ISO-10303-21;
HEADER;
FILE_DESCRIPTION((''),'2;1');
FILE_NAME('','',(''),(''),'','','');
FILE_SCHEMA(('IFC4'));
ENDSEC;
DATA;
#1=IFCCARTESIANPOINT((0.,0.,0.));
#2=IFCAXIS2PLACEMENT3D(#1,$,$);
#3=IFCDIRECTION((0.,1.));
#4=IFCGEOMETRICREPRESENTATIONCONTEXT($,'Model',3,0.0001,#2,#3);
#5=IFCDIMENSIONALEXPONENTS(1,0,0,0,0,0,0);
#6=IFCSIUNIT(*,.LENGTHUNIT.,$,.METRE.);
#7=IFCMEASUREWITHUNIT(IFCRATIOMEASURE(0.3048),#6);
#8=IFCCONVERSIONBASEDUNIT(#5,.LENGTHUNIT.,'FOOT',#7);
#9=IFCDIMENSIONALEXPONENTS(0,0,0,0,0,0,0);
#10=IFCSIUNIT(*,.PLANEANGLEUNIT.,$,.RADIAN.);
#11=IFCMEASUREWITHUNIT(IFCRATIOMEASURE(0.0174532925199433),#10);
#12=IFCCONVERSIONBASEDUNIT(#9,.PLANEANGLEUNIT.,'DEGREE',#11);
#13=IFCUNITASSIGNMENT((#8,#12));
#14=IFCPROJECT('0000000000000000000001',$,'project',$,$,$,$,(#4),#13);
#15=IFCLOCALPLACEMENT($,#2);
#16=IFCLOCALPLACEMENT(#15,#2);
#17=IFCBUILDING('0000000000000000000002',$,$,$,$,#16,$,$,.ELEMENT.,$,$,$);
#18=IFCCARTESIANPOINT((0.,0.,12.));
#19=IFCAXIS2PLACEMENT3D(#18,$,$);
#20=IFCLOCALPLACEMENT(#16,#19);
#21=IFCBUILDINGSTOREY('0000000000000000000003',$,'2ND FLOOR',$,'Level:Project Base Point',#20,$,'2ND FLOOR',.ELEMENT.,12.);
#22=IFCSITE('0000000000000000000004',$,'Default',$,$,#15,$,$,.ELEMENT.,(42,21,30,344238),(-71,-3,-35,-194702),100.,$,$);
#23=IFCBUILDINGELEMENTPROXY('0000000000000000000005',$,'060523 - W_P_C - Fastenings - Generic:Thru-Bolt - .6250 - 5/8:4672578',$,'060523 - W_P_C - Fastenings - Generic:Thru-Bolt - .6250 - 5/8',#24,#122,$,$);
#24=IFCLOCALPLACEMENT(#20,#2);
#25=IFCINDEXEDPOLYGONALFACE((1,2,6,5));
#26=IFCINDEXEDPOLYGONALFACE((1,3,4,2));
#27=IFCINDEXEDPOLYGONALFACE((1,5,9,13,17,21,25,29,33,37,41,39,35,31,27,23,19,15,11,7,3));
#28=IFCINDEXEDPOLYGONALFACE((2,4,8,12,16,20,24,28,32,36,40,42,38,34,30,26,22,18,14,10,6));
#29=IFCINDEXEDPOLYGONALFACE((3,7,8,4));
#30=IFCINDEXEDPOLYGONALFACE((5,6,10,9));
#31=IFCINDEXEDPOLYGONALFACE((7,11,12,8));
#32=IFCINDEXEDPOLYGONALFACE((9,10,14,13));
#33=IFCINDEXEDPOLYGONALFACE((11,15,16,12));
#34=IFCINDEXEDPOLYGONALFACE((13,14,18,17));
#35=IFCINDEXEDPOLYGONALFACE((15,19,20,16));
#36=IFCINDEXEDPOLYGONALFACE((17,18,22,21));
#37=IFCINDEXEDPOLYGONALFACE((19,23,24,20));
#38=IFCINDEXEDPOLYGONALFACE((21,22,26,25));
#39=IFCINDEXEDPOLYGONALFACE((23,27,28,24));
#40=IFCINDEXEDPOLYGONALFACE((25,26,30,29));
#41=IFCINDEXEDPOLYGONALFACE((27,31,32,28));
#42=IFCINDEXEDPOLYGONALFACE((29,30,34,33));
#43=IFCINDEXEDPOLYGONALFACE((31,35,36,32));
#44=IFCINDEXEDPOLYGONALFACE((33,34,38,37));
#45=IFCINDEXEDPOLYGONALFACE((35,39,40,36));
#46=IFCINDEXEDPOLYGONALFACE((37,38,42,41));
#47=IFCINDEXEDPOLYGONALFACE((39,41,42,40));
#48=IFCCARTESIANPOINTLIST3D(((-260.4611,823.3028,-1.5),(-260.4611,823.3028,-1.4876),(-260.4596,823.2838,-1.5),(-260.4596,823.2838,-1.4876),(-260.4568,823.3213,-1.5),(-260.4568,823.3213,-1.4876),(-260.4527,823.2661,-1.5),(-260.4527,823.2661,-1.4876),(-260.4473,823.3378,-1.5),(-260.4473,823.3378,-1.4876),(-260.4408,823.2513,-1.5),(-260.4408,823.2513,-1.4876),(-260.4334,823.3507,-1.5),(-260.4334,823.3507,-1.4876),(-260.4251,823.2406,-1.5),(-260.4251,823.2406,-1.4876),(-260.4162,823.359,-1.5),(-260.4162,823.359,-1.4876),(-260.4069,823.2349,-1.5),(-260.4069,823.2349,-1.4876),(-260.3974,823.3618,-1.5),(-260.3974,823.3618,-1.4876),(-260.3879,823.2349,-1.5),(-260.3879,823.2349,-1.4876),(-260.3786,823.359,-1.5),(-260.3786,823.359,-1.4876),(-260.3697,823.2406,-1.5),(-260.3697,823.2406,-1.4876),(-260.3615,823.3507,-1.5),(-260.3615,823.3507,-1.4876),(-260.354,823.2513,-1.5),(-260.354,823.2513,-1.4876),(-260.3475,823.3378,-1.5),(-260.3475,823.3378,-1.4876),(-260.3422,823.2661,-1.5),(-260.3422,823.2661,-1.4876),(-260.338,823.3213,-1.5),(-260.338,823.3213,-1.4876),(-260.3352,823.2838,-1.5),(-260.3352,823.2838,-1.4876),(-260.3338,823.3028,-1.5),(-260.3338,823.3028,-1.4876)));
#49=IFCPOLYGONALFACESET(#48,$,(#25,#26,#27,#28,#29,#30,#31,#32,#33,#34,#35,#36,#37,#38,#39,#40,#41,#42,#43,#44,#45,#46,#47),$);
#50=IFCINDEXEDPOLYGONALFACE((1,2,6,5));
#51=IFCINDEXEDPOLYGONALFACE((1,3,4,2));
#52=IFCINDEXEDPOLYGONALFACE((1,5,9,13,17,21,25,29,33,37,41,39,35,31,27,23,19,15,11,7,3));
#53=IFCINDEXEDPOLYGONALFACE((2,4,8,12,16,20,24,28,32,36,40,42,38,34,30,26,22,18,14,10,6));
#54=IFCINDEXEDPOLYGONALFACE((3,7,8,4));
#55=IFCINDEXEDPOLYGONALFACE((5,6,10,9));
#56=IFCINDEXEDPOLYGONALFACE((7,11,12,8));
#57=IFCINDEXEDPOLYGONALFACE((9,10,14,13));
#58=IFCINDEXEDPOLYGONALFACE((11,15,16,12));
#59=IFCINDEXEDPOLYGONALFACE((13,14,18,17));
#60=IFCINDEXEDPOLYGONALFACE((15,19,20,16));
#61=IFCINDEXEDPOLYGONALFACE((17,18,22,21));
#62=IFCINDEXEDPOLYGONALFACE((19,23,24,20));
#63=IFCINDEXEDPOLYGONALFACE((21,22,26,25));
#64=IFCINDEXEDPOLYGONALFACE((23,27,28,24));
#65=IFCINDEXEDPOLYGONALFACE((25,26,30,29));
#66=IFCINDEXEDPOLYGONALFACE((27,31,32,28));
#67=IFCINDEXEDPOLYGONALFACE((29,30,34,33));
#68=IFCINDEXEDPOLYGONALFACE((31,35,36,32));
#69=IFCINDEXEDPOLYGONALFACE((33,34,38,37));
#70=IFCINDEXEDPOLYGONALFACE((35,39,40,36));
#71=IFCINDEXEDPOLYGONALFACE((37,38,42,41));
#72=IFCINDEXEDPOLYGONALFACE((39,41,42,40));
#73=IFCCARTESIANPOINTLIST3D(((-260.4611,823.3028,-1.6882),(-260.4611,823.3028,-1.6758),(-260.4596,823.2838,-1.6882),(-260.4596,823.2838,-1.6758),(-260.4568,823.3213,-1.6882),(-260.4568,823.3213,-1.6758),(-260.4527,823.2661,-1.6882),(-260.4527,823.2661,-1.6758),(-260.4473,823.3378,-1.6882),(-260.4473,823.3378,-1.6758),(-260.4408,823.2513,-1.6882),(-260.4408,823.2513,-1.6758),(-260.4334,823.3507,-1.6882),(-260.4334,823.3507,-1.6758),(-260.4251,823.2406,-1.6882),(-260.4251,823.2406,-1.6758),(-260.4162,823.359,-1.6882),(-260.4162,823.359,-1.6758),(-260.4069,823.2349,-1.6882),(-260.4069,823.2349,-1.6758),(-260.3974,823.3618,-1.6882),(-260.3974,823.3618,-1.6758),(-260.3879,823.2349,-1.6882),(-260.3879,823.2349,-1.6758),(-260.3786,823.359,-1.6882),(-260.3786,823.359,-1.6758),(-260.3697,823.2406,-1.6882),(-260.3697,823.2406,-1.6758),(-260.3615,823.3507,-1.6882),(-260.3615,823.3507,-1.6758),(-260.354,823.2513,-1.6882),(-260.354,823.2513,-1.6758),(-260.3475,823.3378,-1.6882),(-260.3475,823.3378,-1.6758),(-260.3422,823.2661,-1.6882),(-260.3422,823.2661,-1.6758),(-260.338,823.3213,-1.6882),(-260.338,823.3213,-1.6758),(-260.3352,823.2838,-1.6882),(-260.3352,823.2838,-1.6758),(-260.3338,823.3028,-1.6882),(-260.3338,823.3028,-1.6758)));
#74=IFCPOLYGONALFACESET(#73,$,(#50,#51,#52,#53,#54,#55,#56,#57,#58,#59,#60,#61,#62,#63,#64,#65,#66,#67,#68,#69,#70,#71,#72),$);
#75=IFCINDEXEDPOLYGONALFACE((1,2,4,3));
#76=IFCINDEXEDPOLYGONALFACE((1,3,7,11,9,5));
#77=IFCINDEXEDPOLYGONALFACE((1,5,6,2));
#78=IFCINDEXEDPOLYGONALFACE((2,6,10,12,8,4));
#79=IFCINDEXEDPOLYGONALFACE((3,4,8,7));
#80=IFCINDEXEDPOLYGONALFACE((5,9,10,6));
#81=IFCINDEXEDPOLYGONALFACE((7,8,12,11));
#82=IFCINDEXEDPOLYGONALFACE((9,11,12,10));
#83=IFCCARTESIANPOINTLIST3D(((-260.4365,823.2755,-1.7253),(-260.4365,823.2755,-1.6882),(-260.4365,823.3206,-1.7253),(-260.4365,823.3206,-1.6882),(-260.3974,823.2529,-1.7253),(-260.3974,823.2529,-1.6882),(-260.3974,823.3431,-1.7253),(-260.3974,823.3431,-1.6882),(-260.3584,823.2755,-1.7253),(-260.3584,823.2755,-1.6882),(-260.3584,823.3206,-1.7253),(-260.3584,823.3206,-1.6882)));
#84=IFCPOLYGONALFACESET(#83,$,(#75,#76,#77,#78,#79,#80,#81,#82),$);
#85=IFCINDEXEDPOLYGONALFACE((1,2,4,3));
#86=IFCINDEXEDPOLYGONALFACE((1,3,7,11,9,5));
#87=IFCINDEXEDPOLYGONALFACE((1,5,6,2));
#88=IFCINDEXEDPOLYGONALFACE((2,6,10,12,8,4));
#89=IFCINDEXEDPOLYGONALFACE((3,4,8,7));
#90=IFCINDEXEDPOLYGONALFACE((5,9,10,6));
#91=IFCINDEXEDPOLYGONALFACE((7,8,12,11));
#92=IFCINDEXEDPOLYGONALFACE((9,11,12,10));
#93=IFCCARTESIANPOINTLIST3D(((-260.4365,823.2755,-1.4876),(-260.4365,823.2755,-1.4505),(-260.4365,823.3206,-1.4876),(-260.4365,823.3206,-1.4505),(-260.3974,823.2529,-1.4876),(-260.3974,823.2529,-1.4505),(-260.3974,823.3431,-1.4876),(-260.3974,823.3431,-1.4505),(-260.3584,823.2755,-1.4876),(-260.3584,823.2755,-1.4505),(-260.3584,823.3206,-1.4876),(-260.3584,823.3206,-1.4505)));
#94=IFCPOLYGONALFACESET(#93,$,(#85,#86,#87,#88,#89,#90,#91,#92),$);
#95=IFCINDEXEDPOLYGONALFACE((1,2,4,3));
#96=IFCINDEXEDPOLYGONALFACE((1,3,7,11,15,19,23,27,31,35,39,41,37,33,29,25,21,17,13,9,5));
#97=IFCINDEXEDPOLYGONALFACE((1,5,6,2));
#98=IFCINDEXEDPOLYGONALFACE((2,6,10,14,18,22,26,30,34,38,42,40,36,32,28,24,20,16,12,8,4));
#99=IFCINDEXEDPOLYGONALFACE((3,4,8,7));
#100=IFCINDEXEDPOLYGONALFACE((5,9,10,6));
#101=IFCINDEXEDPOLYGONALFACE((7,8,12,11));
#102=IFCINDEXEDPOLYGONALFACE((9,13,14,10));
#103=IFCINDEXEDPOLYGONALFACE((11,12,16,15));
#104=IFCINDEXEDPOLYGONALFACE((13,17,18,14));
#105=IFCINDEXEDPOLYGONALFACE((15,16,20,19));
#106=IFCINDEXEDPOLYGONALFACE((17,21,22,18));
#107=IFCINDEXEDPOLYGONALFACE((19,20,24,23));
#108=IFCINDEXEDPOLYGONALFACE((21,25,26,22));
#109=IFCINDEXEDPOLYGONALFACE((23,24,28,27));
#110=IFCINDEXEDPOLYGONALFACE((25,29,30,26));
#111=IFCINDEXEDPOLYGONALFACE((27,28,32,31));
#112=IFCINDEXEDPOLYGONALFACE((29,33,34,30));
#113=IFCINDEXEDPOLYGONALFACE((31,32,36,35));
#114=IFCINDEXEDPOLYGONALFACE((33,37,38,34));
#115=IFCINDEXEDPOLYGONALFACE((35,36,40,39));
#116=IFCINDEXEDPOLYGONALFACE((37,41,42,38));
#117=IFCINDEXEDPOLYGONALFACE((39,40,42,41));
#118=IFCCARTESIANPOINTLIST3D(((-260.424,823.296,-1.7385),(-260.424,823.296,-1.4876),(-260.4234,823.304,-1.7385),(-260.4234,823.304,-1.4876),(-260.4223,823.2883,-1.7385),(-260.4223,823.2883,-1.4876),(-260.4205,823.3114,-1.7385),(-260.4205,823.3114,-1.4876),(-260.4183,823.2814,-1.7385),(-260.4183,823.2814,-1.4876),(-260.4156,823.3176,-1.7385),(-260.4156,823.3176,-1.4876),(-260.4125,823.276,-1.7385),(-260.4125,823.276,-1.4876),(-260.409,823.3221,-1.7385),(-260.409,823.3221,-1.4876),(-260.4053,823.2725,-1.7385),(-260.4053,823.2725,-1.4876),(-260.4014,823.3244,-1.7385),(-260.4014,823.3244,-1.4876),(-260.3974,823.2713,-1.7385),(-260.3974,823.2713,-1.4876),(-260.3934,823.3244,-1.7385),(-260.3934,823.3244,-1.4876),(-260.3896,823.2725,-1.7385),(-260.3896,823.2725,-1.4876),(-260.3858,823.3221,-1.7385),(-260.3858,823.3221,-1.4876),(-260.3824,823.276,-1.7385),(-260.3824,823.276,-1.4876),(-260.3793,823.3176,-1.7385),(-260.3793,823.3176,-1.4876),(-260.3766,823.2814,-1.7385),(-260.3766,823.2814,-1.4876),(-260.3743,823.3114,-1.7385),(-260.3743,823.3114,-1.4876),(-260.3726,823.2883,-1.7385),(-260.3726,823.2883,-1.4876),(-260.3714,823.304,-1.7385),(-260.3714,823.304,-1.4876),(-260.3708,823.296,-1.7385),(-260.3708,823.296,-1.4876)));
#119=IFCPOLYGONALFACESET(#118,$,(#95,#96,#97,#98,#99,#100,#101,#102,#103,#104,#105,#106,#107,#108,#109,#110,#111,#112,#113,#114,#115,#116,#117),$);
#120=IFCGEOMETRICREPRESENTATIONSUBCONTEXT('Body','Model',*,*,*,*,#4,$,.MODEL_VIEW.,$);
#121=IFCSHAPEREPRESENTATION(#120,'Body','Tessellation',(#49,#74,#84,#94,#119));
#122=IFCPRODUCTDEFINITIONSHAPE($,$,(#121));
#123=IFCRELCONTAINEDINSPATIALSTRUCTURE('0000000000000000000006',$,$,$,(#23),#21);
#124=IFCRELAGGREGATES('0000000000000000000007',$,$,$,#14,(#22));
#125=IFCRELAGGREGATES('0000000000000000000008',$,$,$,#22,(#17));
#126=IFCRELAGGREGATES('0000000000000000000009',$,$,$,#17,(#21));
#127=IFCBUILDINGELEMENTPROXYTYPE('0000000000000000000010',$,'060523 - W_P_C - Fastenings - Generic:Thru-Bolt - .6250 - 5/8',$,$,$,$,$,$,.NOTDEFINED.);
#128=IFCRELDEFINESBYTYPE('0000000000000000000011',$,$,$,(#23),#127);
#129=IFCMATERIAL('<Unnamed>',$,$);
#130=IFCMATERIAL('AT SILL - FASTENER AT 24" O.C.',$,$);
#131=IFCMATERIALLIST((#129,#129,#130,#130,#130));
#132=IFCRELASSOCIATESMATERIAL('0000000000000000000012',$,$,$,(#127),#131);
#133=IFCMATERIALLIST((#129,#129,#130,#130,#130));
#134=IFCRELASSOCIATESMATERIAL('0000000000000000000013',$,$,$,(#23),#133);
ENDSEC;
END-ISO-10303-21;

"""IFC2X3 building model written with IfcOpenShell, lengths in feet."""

from ifc_helpers import new_model, entity, si_unit, converted_unit, direction, frame, frame_2d, origin, place, context, subcontext, project, spatial, polyline, circle, outline, extrude, source, transform, mapped, material, material_list, type_object, type_shapes, element, save


model = new_model("IFC2X3")

# Units and contexts
model_context = context("Model", 3, precision=0.0001, world=origin(), true_north=direction((0.0, 1.0)))
body_context = subcontext(model_context, "Body", "Model", "MODEL_VIEW")
ifc_project = project(units=[converted_unit("LENGTHUNIT", "FOOT", entity("IfcRatioMeasure", 0.3048), si_unit("LENGTHUNIT", "METRE"), dimensions=[1, 0, 0, 0, 0, 0, 0]), converted_unit("PLANEANGLEUNIT", "DEGREE", entity("IfcRatioMeasure", 0.0174532925199433), si_unit("PLANEANGLEUNIT", "RADIAN"), dimensions=[0, 0, 0, 0, 0, 0, 0])], contexts=[model_context])

# Site, building, storey
site_placement = place(None, origin())
site = spatial("IfcSite", under=ifc_project, at=site_placement, Name="Default", CompositionType="ELEMENT", RefLatitude=(42, 21, 30, 344238), RefLongitude=(-71, -3, -35, -194702), RefElevation=100.0)
building_placement = place(site_placement, origin())
building = spatial("IfcBuilding", under=site, at=building_placement, CompositionType="ELEMENT")
storey_placement = place(building_placement, frame((0.0, 0.0, 12.0)))
storey = spatial("IfcBuildingStorey", under=building, at=storey_placement, Name="2ND FLOOR", ObjectType="Level:Project Base Point", LongName="2ND FLOOR", CompositionType="ELEMENT", Elevation=12.0)

# Building element proxy
ifc_material_1 = material(Name="<Unnamed>")
ifc_material_2 = material(Name="AT SILL - FASTENER AT 24\" O.C.")
ifc_material_list_1 = material_list([ifc_material_1, ifc_material_1, ifc_material_2, ifc_material_2, ifc_material_2])
ifc_material_list_2 = material_list([ifc_material_1, ifc_material_1, ifc_material_2, ifc_material_2, ifc_material_2])
building_element_proxy_type_1 = type_object("IfcBuildingElementProxyType", Name="060523 - W_P_C - Fastenings - Generic:Thru-Bolt - .6250 - 5/8", PredefinedType="NOTDEFINED", material=ifc_material_list_2)
shared_shape_1 = source(origin(), body_context, "Body", "SweptSolid", [
    extrude(circle(Radius=0.0638, at=frame_2d((0.0, 0.0), x_axis=(1.0, 0.0))), frame((0.0, 0.0, 0.0), z_axis=(0.0, 0.0, 1.0), x_axis=(0.0, 1.0, 0.0)), (0.0, 0.0, 1.0), 0.0124),
    extrude(circle(Radius=0.0638, at=frame_2d((0.0, 0.0), x_axis=(1.0, 0.0))), frame((0.0, 0.0, -0.1882), z_axis=(0.0, 0.0, 1.0), x_axis=(0.0, 1.0, 0.0)), (0.0, 0.0, 1.0), 0.0124),
    extrude(outline(polyline([(-0.0226, -0.0391), (0.0226, -0.0391), (0.0451, 0.0), (0.0226, 0.0391), (-0.0226, 0.0391), (-0.0451, 0.0), (-0.0226, -0.0391)])), frame((0.0, 0.0, -0.2253), z_axis=(0.0, 0.0, 1.0), x_axis=(0.0, -1.0, 0.0)), (0.0, 0.0, 1.0), 0.0371),
    extrude(outline(polyline([(-0.0226, -0.0391), (0.0226, -0.0391), (0.0451, 0.0), (0.0226, 0.0391), (-0.0226, 0.0391), (-0.0451, 0.0), (-0.0226, -0.0391)])), frame((0.0, 0.0, 0.0124), z_axis=(0.0, 0.0, 1.0), x_axis=(0.866025, -0.5, 0.0)), (0.0, 0.0, 1.0), 0.0371),
    extrude(circle(Radius=0.0267, at=frame_2d((0.0, 0.0), x_axis=(1.0, 0.0))), frame((0.0, 0.0, -0.2385), z_axis=(0.0, 0.0, 1.0), x_axis=(0.0, -1.0, 0.0)), (0.0, 0.0, 1.0), 0.2509),
])
type_shapes(building_element_proxy_type_1, [shared_shape_1])
proxy_1_placement = place(storey_placement, frame((-260.3974, 823.298, -1.5)))
element("IfcBuildingElementProxy", 1, at=proxy_1_placement, inside=storey, type_object=building_element_proxy_type_1, material=ifc_material_list_1, Name="060523 - W_P_C - Fastenings - Generic:Thru-Bolt - .6250 - 5/8:4672578", ObjectType="060523 - W_P_C - Fastenings - Generic:Thru-Bolt - .6250 - 5/8", context=body_context, shape_type="MappedRepresentation", body=[
    mapped(shared_shape_1, transform((0.0, 0.0, 0.0), scale=1.0)),
])

save(model, "model.ifc")
